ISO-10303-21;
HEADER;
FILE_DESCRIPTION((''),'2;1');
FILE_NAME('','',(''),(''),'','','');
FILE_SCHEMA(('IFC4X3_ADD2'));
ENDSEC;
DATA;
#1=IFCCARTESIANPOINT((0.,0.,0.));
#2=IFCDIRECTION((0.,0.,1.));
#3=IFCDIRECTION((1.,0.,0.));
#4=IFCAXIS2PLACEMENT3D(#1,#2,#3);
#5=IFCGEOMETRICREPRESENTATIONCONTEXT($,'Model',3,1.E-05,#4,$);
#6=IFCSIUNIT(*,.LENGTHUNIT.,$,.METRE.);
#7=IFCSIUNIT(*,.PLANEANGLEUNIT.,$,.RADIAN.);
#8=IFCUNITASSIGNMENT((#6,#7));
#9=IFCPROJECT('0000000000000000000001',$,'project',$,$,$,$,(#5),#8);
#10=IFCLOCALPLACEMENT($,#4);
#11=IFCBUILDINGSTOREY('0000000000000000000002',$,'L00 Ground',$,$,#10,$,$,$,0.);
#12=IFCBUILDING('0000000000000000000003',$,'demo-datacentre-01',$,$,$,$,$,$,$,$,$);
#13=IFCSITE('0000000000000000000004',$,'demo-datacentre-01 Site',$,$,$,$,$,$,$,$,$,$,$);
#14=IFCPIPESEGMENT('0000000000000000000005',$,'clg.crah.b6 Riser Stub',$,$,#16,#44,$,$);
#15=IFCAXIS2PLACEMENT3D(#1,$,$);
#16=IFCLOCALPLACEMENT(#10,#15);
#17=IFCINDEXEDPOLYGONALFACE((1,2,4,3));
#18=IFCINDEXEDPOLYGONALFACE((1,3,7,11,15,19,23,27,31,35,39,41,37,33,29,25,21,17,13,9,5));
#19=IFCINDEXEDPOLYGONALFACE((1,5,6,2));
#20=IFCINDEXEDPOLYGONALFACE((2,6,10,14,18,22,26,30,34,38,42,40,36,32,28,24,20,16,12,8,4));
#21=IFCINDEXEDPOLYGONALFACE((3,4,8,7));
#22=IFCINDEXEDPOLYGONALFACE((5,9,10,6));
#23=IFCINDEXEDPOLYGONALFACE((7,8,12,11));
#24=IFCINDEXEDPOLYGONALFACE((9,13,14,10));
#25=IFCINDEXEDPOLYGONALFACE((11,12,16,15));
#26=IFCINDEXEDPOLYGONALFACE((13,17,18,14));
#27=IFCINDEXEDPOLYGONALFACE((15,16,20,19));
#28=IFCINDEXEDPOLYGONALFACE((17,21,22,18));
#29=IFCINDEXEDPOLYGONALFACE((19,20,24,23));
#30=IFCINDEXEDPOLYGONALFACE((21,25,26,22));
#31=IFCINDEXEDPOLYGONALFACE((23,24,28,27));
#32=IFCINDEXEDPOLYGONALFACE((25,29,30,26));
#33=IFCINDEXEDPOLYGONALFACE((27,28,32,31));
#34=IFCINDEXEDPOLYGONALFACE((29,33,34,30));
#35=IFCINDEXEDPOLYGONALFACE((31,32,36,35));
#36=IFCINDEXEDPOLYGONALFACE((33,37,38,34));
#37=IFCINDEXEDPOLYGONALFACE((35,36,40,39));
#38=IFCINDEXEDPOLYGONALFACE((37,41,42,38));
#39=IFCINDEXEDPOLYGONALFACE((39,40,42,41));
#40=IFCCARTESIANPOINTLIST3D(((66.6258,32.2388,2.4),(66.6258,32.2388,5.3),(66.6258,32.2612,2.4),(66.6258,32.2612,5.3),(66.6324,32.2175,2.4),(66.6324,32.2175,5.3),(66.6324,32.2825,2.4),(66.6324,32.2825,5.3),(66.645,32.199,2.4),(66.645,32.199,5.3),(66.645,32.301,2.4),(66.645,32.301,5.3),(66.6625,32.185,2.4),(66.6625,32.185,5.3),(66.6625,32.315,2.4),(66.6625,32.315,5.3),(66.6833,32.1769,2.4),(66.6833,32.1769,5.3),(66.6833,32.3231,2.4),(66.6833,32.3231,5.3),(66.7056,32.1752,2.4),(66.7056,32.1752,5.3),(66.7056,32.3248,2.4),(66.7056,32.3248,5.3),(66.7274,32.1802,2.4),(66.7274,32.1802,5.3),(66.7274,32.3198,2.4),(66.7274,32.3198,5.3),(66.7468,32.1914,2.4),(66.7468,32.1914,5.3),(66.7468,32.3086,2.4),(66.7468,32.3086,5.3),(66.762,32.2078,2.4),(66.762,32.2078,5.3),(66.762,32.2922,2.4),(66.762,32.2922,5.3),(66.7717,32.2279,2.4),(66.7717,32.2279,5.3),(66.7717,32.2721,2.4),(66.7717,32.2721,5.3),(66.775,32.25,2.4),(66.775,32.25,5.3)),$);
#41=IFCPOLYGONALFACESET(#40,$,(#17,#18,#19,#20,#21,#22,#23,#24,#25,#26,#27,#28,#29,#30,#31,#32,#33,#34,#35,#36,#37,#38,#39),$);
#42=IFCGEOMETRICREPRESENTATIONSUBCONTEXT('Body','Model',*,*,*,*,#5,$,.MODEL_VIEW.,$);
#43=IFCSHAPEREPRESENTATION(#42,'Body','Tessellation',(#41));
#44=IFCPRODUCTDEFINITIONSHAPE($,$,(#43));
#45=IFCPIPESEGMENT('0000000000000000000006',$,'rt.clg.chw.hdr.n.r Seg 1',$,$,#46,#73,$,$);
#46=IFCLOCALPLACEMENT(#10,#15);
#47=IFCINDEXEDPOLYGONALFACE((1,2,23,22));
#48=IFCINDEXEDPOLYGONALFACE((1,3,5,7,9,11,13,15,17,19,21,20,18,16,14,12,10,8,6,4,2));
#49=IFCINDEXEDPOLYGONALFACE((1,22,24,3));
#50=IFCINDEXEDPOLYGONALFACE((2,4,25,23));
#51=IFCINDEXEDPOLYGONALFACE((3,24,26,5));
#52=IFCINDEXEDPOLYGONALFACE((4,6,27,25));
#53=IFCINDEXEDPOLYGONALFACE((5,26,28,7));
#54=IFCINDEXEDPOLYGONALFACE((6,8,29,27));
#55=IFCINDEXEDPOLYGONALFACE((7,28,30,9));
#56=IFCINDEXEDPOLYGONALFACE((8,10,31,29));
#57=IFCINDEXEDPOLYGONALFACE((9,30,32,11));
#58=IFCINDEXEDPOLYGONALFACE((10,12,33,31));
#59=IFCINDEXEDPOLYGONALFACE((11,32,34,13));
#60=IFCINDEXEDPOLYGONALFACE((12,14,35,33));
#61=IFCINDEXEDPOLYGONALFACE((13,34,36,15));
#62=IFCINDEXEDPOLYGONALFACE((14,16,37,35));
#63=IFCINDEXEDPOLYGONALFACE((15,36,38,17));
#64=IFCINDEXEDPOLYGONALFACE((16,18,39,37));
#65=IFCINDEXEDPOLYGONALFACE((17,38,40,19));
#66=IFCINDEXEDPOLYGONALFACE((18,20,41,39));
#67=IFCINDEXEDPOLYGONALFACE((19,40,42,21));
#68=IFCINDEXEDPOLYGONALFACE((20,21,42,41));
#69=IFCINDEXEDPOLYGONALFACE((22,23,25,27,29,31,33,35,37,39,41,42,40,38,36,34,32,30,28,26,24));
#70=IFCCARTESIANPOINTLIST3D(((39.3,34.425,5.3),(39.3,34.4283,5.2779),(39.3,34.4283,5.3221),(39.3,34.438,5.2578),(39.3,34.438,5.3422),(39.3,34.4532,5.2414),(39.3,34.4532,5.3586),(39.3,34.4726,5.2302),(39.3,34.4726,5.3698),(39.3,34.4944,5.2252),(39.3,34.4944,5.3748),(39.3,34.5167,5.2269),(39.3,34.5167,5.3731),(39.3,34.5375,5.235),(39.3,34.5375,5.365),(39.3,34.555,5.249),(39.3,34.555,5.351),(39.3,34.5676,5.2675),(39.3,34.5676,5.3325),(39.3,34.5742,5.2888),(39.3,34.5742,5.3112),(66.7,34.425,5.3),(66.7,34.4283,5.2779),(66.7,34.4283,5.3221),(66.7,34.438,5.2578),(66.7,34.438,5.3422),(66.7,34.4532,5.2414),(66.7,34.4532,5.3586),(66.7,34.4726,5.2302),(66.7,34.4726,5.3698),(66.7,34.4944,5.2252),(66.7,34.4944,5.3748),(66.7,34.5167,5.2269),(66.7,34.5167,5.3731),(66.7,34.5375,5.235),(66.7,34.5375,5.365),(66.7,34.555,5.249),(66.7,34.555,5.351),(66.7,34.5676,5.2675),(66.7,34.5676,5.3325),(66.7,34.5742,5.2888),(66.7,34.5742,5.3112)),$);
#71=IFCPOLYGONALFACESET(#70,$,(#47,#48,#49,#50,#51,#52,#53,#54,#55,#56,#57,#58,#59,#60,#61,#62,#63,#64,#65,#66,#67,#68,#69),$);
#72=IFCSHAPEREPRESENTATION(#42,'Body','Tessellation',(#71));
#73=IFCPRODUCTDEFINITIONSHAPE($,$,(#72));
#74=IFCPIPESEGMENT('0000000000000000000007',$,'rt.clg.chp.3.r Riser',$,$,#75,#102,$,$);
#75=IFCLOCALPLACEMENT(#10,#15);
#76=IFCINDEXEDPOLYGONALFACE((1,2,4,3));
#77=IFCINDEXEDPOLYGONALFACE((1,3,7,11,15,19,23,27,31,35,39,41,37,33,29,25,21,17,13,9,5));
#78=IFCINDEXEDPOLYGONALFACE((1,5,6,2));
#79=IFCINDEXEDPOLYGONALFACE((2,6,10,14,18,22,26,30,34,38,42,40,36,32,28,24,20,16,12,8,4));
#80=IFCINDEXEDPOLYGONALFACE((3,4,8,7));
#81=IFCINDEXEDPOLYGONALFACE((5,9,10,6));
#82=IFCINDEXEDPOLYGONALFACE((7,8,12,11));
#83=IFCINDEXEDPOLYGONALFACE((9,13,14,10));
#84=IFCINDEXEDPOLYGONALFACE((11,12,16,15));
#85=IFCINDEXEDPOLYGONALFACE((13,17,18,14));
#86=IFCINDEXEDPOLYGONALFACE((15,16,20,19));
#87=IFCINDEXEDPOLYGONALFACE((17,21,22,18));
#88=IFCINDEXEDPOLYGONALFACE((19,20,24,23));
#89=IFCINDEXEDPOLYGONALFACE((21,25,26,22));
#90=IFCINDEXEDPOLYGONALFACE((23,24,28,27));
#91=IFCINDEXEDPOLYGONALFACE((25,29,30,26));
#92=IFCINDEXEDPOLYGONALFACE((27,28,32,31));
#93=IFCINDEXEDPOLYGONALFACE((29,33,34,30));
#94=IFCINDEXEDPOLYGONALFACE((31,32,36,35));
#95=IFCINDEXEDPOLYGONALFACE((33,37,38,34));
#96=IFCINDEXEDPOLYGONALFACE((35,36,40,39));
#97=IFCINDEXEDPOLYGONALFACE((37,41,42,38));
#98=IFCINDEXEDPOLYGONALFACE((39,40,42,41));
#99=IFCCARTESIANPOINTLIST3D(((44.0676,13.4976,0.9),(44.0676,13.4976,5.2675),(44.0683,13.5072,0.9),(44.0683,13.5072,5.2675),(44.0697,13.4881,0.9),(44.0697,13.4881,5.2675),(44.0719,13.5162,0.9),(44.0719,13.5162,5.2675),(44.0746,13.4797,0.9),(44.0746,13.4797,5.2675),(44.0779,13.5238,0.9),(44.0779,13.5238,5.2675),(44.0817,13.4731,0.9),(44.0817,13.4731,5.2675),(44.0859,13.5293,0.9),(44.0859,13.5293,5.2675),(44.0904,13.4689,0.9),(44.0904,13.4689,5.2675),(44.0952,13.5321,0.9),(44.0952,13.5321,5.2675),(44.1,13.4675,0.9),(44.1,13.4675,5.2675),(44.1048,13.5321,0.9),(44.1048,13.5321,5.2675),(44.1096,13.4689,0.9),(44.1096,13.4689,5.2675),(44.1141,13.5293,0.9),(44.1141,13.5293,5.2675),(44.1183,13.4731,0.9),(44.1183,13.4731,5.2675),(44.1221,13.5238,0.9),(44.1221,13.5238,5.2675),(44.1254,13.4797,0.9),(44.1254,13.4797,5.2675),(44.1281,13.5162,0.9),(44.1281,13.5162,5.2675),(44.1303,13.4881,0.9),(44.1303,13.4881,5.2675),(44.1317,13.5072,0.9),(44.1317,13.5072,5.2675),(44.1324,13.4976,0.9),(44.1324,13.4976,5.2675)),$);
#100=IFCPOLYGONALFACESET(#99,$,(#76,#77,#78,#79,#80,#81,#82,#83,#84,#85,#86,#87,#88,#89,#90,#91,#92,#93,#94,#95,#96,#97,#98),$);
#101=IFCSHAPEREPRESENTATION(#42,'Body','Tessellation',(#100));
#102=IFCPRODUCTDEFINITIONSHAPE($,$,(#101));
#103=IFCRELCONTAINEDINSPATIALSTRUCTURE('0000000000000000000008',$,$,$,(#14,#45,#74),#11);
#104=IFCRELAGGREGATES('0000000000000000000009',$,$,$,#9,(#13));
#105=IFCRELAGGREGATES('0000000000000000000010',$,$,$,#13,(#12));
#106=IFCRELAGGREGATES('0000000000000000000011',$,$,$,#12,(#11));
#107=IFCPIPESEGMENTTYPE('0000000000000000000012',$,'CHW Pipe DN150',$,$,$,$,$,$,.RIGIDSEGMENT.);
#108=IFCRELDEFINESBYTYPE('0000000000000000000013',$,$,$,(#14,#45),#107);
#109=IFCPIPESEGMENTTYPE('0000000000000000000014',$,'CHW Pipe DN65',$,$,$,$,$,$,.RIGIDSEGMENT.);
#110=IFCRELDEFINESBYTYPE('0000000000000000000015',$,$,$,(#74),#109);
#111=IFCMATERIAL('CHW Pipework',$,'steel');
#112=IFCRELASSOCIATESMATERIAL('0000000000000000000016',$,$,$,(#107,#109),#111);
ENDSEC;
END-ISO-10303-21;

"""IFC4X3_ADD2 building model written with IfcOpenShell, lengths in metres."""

from ifc_helpers import new_model, si_unit, frame, origin_with_axes, place, context, subcontext, project, spatial, circle, extrude, material, type_object, element, save


model = new_model("IFC4X3_ADD2")

# Units and contexts
model_context = context("Model", 3, precision=1e-05, world=origin_with_axes())
body_context = subcontext(model_context, "Body", "Model", "MODEL_VIEW")
ifc_project = project(units=[si_unit("LENGTHUNIT", "METRE"), si_unit("PLANEANGLEUNIT", "RADIAN")], contexts=[model_context])

# Site, building, storey
site = spatial("IfcSite", under=ifc_project, Name="demo-datacentre-01 Site")
building = spatial("IfcBuilding", under=site, Name="demo-datacentre-01")
storey_placement = place(None, origin_with_axes())
storey = spatial("IfcBuildingStorey", under=building, at=storey_placement, Name="L00 Ground", Elevation=0.0)

# Shared definitions
ifc_material = material(Name="CHW Pipework", Category="steel")

# Pipe segments
pipe_segment_type_1 = type_object("IfcPipeSegmentType", Name="CHW Pipe DN150", PredefinedType="RIGIDSEGMENT", material=ifc_material)
for number, where, z_axis, x_axis, name in (
    (1, (66.7, 32.25, 5.3), (0.0, 0.0, -1.0), (1.0, 0.0, 0.0), "clg.crah.b6 Riser Stub"),
):
    element("IfcPipeSegment", number, at=place(storey_placement, frame(where, z_axis=z_axis, x_axis=x_axis)), inside=storey, type_object=pipe_segment_type_1, Name=name, context=body_context, shape_type="SweptSolid", body=[
        extrude(circle(Radius=0.075), origin_with_axes(), (0.0, 0.0, 1.0), 2.9),
    ])
pipe_segment_1_placement = place(storey_placement, frame((66.7, 34.5, 5.3), z_axis=(-1.0, 0.0, 0.0), x_axis=(0.0, -1.0, 0.0)))
element("IfcPipeSegment", 2, at=pipe_segment_1_placement, inside=storey, type_object=pipe_segment_type_1, Name="rt.clg.chw.hdr.n.r Seg 1", context=body_context, shape_type="SweptSolid", body=[
    extrude(circle(Radius=0.075), origin_with_axes(), (0.0, 0.0, 1.0), 27.4),
])
pipe_segment_type_2 = type_object("IfcPipeSegmentType", Name="CHW Pipe DN65", PredefinedType="RIGIDSEGMENT", material=ifc_material)
pipe_segment_2_placement = place(storey_placement, frame((44.1, 13.5, 0.9), z_axis=(0.0, 0.0, 1.0), x_axis=(0.0, -1.0, 0.0)))
element("IfcPipeSegment", 3, at=pipe_segment_2_placement, inside=storey, type_object=pipe_segment_type_2, Name="rt.clg.chp.3.r Riser", context=body_context, shape_type="SweptSolid", body=[
    extrude(circle(Radius=0.0325), origin_with_axes(), (0.0, 0.0, 1.0), 4.3675),
])

save(model, "model.ifc")
